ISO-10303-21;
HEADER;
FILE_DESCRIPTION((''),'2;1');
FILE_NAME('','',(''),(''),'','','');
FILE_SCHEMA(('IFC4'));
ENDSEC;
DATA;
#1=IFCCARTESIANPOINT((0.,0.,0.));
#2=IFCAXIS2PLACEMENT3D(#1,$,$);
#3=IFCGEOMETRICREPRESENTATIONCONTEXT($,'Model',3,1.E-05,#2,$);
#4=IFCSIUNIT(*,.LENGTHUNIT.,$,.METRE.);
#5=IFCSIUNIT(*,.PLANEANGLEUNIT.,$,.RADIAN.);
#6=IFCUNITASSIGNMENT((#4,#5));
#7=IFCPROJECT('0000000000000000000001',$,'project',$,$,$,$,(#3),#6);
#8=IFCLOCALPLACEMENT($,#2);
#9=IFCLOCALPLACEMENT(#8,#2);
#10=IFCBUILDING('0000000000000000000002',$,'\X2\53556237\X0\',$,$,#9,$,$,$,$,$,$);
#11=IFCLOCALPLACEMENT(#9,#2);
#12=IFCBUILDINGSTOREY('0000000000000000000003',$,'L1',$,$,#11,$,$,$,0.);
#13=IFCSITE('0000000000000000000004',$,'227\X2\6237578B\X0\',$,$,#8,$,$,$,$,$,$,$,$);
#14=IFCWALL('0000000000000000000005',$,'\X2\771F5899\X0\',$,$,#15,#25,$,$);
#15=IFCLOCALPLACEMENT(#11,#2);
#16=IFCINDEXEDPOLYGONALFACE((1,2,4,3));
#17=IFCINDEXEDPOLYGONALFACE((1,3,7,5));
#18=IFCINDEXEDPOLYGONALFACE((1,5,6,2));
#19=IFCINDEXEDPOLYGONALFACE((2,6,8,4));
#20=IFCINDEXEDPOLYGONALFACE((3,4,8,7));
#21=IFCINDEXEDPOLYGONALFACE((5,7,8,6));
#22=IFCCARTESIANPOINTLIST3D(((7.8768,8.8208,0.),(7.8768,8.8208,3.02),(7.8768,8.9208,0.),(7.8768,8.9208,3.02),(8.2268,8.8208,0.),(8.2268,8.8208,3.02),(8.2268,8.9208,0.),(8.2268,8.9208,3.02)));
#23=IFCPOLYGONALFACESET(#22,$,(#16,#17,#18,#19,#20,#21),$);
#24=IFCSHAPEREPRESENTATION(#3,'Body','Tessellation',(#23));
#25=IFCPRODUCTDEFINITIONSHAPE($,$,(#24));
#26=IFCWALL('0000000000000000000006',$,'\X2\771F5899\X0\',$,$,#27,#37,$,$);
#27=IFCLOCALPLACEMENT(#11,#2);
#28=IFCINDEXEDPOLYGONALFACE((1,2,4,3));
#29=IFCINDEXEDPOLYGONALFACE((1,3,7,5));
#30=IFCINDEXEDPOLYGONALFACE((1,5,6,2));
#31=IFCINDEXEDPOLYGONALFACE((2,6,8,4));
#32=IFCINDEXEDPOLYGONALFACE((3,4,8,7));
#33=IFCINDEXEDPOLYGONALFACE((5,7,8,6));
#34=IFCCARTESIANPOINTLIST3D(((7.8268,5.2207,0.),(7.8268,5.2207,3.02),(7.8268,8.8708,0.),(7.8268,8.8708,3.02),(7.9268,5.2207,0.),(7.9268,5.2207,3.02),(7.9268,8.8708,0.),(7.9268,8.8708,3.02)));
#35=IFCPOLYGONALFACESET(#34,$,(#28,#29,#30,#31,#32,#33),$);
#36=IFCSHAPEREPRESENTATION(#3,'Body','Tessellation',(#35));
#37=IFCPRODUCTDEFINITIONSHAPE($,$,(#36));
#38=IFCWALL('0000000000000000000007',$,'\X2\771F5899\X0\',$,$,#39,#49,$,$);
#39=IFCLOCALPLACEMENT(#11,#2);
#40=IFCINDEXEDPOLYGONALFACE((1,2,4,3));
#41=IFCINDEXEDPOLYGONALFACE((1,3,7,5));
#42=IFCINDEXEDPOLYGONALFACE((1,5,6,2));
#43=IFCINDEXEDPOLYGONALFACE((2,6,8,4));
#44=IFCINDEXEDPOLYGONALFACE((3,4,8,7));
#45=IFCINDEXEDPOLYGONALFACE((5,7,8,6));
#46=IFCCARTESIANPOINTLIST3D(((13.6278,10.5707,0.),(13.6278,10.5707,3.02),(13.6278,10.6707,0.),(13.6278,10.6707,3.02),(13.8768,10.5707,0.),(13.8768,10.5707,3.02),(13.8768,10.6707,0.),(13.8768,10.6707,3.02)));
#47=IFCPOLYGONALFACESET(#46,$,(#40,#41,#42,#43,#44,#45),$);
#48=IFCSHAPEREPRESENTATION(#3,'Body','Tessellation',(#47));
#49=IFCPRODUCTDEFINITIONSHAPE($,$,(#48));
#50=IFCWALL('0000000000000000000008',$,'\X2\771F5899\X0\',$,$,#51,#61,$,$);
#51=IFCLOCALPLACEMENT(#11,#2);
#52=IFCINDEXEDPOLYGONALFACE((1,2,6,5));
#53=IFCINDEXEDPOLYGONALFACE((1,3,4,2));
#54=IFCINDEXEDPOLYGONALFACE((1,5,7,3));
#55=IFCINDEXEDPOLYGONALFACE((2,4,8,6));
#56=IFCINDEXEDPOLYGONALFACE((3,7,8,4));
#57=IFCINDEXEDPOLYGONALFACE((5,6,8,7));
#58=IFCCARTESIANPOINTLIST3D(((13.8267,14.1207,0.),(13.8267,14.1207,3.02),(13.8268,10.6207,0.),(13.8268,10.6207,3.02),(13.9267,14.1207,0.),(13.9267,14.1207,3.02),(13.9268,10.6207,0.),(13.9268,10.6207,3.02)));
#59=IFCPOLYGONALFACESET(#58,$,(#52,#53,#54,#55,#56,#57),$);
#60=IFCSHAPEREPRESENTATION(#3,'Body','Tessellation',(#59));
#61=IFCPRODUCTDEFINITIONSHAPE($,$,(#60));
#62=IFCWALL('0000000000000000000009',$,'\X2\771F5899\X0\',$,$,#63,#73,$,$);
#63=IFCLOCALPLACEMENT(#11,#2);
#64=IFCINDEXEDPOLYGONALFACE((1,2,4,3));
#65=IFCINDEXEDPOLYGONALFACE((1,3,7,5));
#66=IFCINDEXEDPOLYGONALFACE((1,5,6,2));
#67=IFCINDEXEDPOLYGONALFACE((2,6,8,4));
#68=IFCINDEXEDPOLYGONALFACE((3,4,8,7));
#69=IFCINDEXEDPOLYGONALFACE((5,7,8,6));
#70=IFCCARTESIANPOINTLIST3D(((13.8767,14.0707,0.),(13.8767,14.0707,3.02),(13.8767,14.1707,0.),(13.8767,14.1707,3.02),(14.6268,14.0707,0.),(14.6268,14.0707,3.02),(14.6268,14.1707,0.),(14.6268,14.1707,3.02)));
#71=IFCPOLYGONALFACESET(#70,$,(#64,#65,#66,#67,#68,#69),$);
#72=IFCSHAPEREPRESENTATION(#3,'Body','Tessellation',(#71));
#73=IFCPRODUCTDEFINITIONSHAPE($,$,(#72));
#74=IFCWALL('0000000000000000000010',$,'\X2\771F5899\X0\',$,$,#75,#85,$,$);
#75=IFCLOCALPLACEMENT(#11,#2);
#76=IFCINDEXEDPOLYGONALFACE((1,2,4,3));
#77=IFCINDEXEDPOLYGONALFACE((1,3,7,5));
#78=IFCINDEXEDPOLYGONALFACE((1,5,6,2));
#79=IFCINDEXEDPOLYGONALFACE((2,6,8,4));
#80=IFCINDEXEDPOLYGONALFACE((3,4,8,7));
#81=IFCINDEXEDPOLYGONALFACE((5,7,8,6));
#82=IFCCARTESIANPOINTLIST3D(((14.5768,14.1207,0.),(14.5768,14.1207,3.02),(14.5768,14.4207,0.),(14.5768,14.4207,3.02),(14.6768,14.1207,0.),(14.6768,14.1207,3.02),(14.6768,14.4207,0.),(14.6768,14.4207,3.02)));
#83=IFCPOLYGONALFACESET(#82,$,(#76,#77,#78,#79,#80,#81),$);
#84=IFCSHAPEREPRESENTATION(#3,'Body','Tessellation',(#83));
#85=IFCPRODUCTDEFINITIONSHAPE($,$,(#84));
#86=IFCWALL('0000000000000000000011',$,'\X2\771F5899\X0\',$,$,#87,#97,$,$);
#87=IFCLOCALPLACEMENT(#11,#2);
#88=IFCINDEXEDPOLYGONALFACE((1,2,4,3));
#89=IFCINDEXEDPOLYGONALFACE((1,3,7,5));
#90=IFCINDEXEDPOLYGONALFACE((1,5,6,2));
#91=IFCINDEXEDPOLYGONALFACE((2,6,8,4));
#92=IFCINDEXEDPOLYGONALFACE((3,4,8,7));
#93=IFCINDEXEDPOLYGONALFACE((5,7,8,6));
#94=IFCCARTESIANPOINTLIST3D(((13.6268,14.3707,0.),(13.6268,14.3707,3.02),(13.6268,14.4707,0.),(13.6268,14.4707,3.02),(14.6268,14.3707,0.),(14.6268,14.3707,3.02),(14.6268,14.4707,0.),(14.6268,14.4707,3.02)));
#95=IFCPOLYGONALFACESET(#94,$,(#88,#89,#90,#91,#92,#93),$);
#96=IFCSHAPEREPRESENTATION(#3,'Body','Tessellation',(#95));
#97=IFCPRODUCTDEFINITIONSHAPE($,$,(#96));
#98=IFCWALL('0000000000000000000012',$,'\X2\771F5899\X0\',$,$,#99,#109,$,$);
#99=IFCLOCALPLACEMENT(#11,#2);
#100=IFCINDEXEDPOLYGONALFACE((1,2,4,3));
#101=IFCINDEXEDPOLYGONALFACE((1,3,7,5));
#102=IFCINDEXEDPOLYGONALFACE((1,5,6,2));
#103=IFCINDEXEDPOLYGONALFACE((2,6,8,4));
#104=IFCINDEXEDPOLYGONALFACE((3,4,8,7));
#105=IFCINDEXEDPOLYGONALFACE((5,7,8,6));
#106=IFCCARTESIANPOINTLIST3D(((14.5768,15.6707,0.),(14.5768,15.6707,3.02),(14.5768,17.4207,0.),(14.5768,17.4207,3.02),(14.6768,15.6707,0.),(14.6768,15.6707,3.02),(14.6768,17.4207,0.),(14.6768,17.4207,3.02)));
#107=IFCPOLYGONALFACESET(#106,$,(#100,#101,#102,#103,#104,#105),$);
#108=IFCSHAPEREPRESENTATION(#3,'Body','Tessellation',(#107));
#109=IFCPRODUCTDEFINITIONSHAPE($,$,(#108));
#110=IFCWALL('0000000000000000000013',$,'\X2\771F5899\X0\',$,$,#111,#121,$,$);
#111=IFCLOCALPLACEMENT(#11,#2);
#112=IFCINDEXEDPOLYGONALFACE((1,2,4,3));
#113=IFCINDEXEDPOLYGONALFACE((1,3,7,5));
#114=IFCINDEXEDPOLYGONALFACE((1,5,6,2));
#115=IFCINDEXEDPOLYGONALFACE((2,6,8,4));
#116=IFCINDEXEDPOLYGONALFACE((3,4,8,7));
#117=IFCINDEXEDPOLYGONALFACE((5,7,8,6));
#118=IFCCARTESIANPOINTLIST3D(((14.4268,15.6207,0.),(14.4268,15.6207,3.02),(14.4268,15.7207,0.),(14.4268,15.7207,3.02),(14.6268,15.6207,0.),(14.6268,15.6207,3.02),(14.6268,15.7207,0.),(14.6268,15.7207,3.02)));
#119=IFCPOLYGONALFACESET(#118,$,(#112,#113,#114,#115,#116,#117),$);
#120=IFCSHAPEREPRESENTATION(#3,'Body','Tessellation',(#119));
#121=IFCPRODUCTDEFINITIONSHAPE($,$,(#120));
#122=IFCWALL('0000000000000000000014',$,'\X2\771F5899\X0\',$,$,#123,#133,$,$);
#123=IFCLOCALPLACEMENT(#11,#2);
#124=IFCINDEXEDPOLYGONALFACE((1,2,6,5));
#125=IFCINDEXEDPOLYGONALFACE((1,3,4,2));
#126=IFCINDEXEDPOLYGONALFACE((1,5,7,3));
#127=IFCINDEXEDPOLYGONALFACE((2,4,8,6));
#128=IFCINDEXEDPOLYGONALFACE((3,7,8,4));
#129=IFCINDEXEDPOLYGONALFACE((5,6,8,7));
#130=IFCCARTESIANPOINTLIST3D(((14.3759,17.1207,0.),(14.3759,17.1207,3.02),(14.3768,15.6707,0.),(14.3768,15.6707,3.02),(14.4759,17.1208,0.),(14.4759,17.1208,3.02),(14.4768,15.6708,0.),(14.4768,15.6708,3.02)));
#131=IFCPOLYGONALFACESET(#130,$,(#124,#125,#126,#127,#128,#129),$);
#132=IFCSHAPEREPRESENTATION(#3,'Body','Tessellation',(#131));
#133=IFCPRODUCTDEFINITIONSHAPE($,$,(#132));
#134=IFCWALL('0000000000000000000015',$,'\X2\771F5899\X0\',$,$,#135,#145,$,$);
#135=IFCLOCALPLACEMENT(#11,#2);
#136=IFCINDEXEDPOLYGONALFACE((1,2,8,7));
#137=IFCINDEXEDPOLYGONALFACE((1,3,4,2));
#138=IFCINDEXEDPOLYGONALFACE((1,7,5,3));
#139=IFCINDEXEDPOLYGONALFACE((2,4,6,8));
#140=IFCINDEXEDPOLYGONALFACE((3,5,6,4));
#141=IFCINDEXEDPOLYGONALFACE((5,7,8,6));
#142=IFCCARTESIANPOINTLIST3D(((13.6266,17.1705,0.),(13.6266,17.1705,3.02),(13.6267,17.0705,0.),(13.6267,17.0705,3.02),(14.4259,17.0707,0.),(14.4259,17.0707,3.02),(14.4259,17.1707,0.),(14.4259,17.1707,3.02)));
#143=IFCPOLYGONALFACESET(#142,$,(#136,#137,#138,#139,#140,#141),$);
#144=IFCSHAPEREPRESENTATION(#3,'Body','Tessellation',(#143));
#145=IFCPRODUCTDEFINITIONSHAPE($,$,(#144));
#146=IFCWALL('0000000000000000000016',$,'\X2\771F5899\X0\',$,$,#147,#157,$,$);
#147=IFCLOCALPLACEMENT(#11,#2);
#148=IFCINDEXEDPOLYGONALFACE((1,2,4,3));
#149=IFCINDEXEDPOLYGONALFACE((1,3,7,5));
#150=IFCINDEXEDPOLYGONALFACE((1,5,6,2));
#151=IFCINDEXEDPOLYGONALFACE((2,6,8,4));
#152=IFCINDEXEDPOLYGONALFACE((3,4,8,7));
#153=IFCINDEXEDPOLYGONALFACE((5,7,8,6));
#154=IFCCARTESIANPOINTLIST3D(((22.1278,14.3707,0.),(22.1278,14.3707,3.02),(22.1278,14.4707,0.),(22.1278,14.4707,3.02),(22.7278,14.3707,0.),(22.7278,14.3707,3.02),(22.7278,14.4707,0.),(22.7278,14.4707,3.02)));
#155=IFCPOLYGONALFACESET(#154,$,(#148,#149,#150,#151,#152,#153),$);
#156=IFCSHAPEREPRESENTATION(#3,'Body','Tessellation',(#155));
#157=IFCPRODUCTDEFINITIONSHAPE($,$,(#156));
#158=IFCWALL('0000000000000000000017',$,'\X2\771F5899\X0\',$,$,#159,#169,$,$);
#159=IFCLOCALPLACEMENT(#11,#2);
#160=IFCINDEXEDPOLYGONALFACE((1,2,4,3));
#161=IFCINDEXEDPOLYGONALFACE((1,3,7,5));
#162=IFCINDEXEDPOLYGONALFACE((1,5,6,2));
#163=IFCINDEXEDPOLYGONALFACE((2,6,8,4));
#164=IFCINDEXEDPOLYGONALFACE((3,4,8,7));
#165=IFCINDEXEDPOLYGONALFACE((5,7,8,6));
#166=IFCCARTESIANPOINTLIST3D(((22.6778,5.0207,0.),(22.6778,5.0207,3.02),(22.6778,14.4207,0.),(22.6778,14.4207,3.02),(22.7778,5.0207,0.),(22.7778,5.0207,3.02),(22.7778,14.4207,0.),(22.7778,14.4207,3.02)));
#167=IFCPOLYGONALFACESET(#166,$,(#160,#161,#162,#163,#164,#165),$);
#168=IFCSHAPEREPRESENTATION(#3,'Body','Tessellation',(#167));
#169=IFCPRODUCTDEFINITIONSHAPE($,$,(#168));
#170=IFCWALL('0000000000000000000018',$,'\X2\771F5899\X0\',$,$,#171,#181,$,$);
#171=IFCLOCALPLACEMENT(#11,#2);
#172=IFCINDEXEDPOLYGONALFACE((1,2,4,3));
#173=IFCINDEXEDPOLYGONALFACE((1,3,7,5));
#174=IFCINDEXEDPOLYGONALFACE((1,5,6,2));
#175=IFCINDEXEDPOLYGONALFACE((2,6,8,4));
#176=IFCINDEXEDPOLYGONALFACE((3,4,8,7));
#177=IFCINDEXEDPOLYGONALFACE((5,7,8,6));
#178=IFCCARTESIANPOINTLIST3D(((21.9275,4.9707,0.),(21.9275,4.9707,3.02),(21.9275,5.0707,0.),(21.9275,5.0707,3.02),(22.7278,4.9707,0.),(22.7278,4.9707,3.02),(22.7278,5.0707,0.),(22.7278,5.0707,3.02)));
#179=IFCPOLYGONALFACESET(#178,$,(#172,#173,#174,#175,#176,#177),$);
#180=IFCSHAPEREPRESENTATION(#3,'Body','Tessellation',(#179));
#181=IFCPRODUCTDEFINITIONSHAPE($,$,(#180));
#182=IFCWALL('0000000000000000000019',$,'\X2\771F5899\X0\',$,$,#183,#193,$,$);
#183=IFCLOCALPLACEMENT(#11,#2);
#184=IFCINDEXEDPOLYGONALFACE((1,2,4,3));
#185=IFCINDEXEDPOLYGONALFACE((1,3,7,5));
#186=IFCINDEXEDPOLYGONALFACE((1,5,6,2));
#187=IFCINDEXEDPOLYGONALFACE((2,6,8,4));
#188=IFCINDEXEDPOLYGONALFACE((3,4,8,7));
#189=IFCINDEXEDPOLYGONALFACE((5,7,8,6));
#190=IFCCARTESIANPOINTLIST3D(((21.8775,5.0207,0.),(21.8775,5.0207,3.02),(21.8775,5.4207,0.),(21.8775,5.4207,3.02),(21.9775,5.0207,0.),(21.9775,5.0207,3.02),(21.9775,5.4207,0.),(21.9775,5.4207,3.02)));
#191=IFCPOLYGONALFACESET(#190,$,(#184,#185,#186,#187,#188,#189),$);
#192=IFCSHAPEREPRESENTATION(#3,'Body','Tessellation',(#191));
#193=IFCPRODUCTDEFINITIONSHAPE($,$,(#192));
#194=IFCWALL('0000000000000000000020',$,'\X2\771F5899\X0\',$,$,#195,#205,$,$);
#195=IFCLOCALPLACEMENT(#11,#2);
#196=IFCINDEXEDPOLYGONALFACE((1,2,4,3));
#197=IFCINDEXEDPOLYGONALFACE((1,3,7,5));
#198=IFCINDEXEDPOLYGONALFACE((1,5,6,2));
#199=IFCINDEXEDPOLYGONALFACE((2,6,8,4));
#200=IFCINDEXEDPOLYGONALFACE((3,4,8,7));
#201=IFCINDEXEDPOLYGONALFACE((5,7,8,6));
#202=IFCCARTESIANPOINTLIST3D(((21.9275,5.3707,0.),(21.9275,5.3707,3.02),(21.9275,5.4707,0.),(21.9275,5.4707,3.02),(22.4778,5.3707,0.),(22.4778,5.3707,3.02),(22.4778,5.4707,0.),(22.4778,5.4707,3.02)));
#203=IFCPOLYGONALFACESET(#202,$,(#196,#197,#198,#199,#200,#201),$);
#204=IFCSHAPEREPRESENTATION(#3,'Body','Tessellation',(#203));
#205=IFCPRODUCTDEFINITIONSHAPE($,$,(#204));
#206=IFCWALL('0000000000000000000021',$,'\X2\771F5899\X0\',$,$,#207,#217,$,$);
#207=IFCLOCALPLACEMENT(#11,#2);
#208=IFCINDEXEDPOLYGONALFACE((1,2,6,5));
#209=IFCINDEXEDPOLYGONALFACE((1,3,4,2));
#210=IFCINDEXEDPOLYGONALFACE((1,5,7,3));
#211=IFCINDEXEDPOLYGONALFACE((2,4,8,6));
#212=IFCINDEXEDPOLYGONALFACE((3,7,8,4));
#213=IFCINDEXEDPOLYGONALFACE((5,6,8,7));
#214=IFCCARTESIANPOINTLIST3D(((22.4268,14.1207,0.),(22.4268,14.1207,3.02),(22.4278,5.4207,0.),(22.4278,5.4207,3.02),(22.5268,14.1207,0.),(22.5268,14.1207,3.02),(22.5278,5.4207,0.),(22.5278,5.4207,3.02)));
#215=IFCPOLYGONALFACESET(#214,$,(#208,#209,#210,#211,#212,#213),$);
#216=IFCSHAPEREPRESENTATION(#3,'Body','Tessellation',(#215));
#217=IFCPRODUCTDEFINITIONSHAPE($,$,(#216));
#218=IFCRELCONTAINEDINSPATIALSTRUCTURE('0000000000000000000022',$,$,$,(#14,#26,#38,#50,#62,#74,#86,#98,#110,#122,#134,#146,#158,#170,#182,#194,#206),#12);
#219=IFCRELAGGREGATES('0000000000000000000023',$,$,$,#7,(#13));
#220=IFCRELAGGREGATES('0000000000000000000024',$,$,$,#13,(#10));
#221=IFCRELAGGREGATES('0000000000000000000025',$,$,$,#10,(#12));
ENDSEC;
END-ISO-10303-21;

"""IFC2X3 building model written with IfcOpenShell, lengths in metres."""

from ifc_helpers import new_model, si_unit, origin, place, context, project, spatial, polyline, outline, extrude, element, save


model = new_model("IFC2X3")

# Units and contexts
model_context = context("Model", 3, precision=1e-05, world=origin())
ifc_project = project(units=[si_unit("LENGTHUNIT", "METRE"), si_unit("PLANEANGLEUNIT", "RADIAN")], contexts=[model_context])

# Site, building, storey
site_placement = place(None, origin())
site = spatial("IfcSite", under=ifc_project, at=site_placement, Name="227户型")
building_placement = place(site_placement, origin())
building = spatial("IfcBuilding", under=site, at=building_placement, Name="单户")
storey_placement = place(building_placement, origin())
storey = spatial("IfcBuildingStorey", under=building, at=storey_placement, Name="L1", Elevation=0.0)

# Walls
wall_1_placement = place(storey_placement, origin())
element("IfcWall", 1, at=wall_1_placement, inside=storey, Name="真墙", context=model_context, shape_type="SweptSolid", body=[
    extrude(outline(polyline([(8.2268, 8.8208), (7.8768, 8.8208), (7.8768, 8.9208), (8.2268, 8.9208), (8.2268, 8.8208)])), origin(), (0.0, 0.0, 1.0), 3.02),
])
wall_2_placement = place(storey_placement, origin())
element("IfcWall", 2, at=wall_2_placement, inside=storey, Name="真墙", context=model_context, shape_type="SweptSolid", body=[
    extrude(outline(polyline([(7.9268, 8.8708), (7.9268, 5.2207), (7.8268, 5.2207), (7.8268, 8.8708), (7.9268, 8.8708)])), origin(), (0.0, 0.0, 1.0), 3.02),
])
wall_3_placement = place(storey_placement, origin())
element("IfcWall", 3, at=wall_3_placement, inside=storey, Name="真墙", context=model_context, shape_type="SweptSolid", body=[
    extrude(outline(polyline([(13.6278, 10.6707), (13.8768, 10.6707), (13.8768, 10.5707), (13.6278, 10.5707), (13.6278, 10.6707)])), origin(), (0.0, 0.0, 1.0), 3.02),
])
wall_4_placement = place(storey_placement, origin())
element("IfcWall", 4, at=wall_4_placement, inside=storey, Name="真墙", context=model_context, shape_type="SweptSolid", body=[
    extrude(outline(polyline([(13.8268, 10.6207), (13.8267, 14.1207), (13.9267, 14.1207), (13.9268, 10.6207), (13.8268, 10.6207)])), origin(), (0.0, 0.0, 1.0), 3.02),
])
wall_5_placement = place(storey_placement, origin())
element("IfcWall", 5, at=wall_5_placement, inside=storey, Name="真墙", context=model_context, shape_type="SweptSolid", body=[
    extrude(outline(polyline([(13.8767, 14.1707), (14.6268, 14.1707), (14.6268, 14.0707), (13.8767, 14.0707), (13.8767, 14.1707)])), origin(), (0.0, 0.0, 1.0), 3.02),
])
wall_6_placement = place(storey_placement, origin())
element("IfcWall", 6, at=wall_6_placement, inside=storey, Name="真墙", context=model_context, shape_type="SweptSolid", body=[
    extrude(outline(polyline([(14.5768, 14.1207), (14.5768, 14.4207), (14.6768, 14.4207), (14.6768, 14.1207), (14.5768, 14.1207)])), origin(), (0.0, 0.0, 1.0), 3.02),
])
wall_7_placement = place(storey_placement, origin())
element("IfcWall", 7, at=wall_7_placement, inside=storey, Name="真墙", context=model_context, shape_type="SweptSolid", body=[
    extrude(outline(polyline([(14.6268, 14.3707), (13.6268, 14.3707), (13.6268, 14.4707), (14.6268, 14.4707), (14.6268, 14.3707)])), origin(), (0.0, 0.0, 1.0), 3.02),
])

# Walls
wall_8_placement = place(storey_placement, origin())
element("IfcWall", 8, at=wall_8_placement, inside=storey, Name="真墙", context=model_context, shape_type="SweptSolid", body=[
    extrude(outline(polyline([(14.6768, 17.4207), (14.6768, 15.6707), (14.5768, 15.6707), (14.5768, 17.4207), (14.6768, 17.4207)])), origin(), (0.0, 0.0, 1.0), 3.02),
])
wall_9_placement = place(storey_placement, origin())
element("IfcWall", 9, at=wall_9_placement, inside=storey, Name="真墙", context=model_context, shape_type="SweptSolid", body=[
    extrude(outline(polyline([(14.6268, 15.6207), (14.4268, 15.6207), (14.4268, 15.7207), (14.6268, 15.7207), (14.6268, 15.6207)])), origin(), (0.0, 0.0, 1.0), 3.02),
])
wall_10_placement = place(storey_placement, origin())
element("IfcWall", 10, at=wall_10_placement, inside=storey, Name="真墙", context=model_context, shape_type="SweptSolid", body=[
    extrude(outline(polyline([(14.3768, 15.6707), (14.3759, 17.1207), (14.4759, 17.1208), (14.4768, 15.6708), (14.3768, 15.6707)])), origin(), (0.0, 0.0, 1.0), 3.02),
])
wall_11_placement = place(storey_placement, origin())
element("IfcWall", 11, at=wall_11_placement, inside=storey, Name="真墙", context=model_context, shape_type="SweptSolid", body=[
    extrude(outline(polyline([(14.4259, 17.0707), (13.6267, 17.0705), (13.6266, 17.1705), (14.4259, 17.1707), (14.4259, 17.0707)])), origin(), (0.0, 0.0, 1.0), 3.02),
])
wall_12_placement = place(storey_placement, origin())
element("IfcWall", 12, at=wall_12_placement, inside=storey, Name="真墙", context=model_context, shape_type="SweptSolid", body=[
    extrude(outline(polyline([(22.1278, 14.4707), (22.7278, 14.4707), (22.7278, 14.3707), (22.1278, 14.3707), (22.1278, 14.4707)])), origin(), (0.0, 0.0, 1.0), 3.02),
])
wall_13_placement = place(storey_placement, origin())
element("IfcWall", 13, at=wall_13_placement, inside=storey, Name="真墙", context=model_context, shape_type="SweptSolid", body=[
    extrude(outline(polyline([(22.7778, 14.4207), (22.7778, 5.0207), (22.6778, 5.0207), (22.6778, 14.4207), (22.7778, 14.4207)])), origin(), (0.0, 0.0, 1.0), 3.02),
])
wall_14_placement = place(storey_placement, origin())
element("IfcWall", 14, at=wall_14_placement, inside=storey, Name="真墙", context=model_context, shape_type="SweptSolid", body=[
    extrude(outline(polyline([(22.7278, 4.9707), (21.9275, 4.9707), (21.9275, 5.0707), (22.7278, 5.0707), (22.7278, 4.9707)])), origin(), (0.0, 0.0, 1.0), 3.02),
])
wall_15_placement = place(storey_placement, origin())
element("IfcWall", 15, at=wall_15_placement, inside=storey, Name="真墙", context=model_context, shape_type="SweptSolid", body=[
    extrude(outline(polyline([(21.8775, 5.0207), (21.8775, 5.4207), (21.9775, 5.4207), (21.9775, 5.0207), (21.8775, 5.0207)])), origin(), (0.0, 0.0, 1.0), 3.02),
])
wall_16_placement = place(storey_placement, origin())
element("IfcWall", 16, at=wall_16_placement, inside=storey, Name="真墙", context=model_context, shape_type="SweptSolid", body=[
    extrude(outline(polyline([(21.9275, 5.4707), (22.4778, 5.4707), (22.4778, 5.3707), (21.9275, 5.3707), (21.9275, 5.4707)])), origin(), (0.0, 0.0, 1.0), 3.02),
])
wall_17_placement = place(storey_placement, origin())
element("IfcWall", 17, at=wall_17_placement, inside=storey, Name="真墙", context=model_context, shape_type="SweptSolid", body=[
    extrude(outline(polyline([(22.4278, 5.4207), (22.4268, 14.1207), (22.5268, 14.1207), (22.5278, 5.4207), (22.4278, 5.4207)])), origin(), (0.0, 0.0, 1.0), 3.02),
])

save(model, "model.ifc")
